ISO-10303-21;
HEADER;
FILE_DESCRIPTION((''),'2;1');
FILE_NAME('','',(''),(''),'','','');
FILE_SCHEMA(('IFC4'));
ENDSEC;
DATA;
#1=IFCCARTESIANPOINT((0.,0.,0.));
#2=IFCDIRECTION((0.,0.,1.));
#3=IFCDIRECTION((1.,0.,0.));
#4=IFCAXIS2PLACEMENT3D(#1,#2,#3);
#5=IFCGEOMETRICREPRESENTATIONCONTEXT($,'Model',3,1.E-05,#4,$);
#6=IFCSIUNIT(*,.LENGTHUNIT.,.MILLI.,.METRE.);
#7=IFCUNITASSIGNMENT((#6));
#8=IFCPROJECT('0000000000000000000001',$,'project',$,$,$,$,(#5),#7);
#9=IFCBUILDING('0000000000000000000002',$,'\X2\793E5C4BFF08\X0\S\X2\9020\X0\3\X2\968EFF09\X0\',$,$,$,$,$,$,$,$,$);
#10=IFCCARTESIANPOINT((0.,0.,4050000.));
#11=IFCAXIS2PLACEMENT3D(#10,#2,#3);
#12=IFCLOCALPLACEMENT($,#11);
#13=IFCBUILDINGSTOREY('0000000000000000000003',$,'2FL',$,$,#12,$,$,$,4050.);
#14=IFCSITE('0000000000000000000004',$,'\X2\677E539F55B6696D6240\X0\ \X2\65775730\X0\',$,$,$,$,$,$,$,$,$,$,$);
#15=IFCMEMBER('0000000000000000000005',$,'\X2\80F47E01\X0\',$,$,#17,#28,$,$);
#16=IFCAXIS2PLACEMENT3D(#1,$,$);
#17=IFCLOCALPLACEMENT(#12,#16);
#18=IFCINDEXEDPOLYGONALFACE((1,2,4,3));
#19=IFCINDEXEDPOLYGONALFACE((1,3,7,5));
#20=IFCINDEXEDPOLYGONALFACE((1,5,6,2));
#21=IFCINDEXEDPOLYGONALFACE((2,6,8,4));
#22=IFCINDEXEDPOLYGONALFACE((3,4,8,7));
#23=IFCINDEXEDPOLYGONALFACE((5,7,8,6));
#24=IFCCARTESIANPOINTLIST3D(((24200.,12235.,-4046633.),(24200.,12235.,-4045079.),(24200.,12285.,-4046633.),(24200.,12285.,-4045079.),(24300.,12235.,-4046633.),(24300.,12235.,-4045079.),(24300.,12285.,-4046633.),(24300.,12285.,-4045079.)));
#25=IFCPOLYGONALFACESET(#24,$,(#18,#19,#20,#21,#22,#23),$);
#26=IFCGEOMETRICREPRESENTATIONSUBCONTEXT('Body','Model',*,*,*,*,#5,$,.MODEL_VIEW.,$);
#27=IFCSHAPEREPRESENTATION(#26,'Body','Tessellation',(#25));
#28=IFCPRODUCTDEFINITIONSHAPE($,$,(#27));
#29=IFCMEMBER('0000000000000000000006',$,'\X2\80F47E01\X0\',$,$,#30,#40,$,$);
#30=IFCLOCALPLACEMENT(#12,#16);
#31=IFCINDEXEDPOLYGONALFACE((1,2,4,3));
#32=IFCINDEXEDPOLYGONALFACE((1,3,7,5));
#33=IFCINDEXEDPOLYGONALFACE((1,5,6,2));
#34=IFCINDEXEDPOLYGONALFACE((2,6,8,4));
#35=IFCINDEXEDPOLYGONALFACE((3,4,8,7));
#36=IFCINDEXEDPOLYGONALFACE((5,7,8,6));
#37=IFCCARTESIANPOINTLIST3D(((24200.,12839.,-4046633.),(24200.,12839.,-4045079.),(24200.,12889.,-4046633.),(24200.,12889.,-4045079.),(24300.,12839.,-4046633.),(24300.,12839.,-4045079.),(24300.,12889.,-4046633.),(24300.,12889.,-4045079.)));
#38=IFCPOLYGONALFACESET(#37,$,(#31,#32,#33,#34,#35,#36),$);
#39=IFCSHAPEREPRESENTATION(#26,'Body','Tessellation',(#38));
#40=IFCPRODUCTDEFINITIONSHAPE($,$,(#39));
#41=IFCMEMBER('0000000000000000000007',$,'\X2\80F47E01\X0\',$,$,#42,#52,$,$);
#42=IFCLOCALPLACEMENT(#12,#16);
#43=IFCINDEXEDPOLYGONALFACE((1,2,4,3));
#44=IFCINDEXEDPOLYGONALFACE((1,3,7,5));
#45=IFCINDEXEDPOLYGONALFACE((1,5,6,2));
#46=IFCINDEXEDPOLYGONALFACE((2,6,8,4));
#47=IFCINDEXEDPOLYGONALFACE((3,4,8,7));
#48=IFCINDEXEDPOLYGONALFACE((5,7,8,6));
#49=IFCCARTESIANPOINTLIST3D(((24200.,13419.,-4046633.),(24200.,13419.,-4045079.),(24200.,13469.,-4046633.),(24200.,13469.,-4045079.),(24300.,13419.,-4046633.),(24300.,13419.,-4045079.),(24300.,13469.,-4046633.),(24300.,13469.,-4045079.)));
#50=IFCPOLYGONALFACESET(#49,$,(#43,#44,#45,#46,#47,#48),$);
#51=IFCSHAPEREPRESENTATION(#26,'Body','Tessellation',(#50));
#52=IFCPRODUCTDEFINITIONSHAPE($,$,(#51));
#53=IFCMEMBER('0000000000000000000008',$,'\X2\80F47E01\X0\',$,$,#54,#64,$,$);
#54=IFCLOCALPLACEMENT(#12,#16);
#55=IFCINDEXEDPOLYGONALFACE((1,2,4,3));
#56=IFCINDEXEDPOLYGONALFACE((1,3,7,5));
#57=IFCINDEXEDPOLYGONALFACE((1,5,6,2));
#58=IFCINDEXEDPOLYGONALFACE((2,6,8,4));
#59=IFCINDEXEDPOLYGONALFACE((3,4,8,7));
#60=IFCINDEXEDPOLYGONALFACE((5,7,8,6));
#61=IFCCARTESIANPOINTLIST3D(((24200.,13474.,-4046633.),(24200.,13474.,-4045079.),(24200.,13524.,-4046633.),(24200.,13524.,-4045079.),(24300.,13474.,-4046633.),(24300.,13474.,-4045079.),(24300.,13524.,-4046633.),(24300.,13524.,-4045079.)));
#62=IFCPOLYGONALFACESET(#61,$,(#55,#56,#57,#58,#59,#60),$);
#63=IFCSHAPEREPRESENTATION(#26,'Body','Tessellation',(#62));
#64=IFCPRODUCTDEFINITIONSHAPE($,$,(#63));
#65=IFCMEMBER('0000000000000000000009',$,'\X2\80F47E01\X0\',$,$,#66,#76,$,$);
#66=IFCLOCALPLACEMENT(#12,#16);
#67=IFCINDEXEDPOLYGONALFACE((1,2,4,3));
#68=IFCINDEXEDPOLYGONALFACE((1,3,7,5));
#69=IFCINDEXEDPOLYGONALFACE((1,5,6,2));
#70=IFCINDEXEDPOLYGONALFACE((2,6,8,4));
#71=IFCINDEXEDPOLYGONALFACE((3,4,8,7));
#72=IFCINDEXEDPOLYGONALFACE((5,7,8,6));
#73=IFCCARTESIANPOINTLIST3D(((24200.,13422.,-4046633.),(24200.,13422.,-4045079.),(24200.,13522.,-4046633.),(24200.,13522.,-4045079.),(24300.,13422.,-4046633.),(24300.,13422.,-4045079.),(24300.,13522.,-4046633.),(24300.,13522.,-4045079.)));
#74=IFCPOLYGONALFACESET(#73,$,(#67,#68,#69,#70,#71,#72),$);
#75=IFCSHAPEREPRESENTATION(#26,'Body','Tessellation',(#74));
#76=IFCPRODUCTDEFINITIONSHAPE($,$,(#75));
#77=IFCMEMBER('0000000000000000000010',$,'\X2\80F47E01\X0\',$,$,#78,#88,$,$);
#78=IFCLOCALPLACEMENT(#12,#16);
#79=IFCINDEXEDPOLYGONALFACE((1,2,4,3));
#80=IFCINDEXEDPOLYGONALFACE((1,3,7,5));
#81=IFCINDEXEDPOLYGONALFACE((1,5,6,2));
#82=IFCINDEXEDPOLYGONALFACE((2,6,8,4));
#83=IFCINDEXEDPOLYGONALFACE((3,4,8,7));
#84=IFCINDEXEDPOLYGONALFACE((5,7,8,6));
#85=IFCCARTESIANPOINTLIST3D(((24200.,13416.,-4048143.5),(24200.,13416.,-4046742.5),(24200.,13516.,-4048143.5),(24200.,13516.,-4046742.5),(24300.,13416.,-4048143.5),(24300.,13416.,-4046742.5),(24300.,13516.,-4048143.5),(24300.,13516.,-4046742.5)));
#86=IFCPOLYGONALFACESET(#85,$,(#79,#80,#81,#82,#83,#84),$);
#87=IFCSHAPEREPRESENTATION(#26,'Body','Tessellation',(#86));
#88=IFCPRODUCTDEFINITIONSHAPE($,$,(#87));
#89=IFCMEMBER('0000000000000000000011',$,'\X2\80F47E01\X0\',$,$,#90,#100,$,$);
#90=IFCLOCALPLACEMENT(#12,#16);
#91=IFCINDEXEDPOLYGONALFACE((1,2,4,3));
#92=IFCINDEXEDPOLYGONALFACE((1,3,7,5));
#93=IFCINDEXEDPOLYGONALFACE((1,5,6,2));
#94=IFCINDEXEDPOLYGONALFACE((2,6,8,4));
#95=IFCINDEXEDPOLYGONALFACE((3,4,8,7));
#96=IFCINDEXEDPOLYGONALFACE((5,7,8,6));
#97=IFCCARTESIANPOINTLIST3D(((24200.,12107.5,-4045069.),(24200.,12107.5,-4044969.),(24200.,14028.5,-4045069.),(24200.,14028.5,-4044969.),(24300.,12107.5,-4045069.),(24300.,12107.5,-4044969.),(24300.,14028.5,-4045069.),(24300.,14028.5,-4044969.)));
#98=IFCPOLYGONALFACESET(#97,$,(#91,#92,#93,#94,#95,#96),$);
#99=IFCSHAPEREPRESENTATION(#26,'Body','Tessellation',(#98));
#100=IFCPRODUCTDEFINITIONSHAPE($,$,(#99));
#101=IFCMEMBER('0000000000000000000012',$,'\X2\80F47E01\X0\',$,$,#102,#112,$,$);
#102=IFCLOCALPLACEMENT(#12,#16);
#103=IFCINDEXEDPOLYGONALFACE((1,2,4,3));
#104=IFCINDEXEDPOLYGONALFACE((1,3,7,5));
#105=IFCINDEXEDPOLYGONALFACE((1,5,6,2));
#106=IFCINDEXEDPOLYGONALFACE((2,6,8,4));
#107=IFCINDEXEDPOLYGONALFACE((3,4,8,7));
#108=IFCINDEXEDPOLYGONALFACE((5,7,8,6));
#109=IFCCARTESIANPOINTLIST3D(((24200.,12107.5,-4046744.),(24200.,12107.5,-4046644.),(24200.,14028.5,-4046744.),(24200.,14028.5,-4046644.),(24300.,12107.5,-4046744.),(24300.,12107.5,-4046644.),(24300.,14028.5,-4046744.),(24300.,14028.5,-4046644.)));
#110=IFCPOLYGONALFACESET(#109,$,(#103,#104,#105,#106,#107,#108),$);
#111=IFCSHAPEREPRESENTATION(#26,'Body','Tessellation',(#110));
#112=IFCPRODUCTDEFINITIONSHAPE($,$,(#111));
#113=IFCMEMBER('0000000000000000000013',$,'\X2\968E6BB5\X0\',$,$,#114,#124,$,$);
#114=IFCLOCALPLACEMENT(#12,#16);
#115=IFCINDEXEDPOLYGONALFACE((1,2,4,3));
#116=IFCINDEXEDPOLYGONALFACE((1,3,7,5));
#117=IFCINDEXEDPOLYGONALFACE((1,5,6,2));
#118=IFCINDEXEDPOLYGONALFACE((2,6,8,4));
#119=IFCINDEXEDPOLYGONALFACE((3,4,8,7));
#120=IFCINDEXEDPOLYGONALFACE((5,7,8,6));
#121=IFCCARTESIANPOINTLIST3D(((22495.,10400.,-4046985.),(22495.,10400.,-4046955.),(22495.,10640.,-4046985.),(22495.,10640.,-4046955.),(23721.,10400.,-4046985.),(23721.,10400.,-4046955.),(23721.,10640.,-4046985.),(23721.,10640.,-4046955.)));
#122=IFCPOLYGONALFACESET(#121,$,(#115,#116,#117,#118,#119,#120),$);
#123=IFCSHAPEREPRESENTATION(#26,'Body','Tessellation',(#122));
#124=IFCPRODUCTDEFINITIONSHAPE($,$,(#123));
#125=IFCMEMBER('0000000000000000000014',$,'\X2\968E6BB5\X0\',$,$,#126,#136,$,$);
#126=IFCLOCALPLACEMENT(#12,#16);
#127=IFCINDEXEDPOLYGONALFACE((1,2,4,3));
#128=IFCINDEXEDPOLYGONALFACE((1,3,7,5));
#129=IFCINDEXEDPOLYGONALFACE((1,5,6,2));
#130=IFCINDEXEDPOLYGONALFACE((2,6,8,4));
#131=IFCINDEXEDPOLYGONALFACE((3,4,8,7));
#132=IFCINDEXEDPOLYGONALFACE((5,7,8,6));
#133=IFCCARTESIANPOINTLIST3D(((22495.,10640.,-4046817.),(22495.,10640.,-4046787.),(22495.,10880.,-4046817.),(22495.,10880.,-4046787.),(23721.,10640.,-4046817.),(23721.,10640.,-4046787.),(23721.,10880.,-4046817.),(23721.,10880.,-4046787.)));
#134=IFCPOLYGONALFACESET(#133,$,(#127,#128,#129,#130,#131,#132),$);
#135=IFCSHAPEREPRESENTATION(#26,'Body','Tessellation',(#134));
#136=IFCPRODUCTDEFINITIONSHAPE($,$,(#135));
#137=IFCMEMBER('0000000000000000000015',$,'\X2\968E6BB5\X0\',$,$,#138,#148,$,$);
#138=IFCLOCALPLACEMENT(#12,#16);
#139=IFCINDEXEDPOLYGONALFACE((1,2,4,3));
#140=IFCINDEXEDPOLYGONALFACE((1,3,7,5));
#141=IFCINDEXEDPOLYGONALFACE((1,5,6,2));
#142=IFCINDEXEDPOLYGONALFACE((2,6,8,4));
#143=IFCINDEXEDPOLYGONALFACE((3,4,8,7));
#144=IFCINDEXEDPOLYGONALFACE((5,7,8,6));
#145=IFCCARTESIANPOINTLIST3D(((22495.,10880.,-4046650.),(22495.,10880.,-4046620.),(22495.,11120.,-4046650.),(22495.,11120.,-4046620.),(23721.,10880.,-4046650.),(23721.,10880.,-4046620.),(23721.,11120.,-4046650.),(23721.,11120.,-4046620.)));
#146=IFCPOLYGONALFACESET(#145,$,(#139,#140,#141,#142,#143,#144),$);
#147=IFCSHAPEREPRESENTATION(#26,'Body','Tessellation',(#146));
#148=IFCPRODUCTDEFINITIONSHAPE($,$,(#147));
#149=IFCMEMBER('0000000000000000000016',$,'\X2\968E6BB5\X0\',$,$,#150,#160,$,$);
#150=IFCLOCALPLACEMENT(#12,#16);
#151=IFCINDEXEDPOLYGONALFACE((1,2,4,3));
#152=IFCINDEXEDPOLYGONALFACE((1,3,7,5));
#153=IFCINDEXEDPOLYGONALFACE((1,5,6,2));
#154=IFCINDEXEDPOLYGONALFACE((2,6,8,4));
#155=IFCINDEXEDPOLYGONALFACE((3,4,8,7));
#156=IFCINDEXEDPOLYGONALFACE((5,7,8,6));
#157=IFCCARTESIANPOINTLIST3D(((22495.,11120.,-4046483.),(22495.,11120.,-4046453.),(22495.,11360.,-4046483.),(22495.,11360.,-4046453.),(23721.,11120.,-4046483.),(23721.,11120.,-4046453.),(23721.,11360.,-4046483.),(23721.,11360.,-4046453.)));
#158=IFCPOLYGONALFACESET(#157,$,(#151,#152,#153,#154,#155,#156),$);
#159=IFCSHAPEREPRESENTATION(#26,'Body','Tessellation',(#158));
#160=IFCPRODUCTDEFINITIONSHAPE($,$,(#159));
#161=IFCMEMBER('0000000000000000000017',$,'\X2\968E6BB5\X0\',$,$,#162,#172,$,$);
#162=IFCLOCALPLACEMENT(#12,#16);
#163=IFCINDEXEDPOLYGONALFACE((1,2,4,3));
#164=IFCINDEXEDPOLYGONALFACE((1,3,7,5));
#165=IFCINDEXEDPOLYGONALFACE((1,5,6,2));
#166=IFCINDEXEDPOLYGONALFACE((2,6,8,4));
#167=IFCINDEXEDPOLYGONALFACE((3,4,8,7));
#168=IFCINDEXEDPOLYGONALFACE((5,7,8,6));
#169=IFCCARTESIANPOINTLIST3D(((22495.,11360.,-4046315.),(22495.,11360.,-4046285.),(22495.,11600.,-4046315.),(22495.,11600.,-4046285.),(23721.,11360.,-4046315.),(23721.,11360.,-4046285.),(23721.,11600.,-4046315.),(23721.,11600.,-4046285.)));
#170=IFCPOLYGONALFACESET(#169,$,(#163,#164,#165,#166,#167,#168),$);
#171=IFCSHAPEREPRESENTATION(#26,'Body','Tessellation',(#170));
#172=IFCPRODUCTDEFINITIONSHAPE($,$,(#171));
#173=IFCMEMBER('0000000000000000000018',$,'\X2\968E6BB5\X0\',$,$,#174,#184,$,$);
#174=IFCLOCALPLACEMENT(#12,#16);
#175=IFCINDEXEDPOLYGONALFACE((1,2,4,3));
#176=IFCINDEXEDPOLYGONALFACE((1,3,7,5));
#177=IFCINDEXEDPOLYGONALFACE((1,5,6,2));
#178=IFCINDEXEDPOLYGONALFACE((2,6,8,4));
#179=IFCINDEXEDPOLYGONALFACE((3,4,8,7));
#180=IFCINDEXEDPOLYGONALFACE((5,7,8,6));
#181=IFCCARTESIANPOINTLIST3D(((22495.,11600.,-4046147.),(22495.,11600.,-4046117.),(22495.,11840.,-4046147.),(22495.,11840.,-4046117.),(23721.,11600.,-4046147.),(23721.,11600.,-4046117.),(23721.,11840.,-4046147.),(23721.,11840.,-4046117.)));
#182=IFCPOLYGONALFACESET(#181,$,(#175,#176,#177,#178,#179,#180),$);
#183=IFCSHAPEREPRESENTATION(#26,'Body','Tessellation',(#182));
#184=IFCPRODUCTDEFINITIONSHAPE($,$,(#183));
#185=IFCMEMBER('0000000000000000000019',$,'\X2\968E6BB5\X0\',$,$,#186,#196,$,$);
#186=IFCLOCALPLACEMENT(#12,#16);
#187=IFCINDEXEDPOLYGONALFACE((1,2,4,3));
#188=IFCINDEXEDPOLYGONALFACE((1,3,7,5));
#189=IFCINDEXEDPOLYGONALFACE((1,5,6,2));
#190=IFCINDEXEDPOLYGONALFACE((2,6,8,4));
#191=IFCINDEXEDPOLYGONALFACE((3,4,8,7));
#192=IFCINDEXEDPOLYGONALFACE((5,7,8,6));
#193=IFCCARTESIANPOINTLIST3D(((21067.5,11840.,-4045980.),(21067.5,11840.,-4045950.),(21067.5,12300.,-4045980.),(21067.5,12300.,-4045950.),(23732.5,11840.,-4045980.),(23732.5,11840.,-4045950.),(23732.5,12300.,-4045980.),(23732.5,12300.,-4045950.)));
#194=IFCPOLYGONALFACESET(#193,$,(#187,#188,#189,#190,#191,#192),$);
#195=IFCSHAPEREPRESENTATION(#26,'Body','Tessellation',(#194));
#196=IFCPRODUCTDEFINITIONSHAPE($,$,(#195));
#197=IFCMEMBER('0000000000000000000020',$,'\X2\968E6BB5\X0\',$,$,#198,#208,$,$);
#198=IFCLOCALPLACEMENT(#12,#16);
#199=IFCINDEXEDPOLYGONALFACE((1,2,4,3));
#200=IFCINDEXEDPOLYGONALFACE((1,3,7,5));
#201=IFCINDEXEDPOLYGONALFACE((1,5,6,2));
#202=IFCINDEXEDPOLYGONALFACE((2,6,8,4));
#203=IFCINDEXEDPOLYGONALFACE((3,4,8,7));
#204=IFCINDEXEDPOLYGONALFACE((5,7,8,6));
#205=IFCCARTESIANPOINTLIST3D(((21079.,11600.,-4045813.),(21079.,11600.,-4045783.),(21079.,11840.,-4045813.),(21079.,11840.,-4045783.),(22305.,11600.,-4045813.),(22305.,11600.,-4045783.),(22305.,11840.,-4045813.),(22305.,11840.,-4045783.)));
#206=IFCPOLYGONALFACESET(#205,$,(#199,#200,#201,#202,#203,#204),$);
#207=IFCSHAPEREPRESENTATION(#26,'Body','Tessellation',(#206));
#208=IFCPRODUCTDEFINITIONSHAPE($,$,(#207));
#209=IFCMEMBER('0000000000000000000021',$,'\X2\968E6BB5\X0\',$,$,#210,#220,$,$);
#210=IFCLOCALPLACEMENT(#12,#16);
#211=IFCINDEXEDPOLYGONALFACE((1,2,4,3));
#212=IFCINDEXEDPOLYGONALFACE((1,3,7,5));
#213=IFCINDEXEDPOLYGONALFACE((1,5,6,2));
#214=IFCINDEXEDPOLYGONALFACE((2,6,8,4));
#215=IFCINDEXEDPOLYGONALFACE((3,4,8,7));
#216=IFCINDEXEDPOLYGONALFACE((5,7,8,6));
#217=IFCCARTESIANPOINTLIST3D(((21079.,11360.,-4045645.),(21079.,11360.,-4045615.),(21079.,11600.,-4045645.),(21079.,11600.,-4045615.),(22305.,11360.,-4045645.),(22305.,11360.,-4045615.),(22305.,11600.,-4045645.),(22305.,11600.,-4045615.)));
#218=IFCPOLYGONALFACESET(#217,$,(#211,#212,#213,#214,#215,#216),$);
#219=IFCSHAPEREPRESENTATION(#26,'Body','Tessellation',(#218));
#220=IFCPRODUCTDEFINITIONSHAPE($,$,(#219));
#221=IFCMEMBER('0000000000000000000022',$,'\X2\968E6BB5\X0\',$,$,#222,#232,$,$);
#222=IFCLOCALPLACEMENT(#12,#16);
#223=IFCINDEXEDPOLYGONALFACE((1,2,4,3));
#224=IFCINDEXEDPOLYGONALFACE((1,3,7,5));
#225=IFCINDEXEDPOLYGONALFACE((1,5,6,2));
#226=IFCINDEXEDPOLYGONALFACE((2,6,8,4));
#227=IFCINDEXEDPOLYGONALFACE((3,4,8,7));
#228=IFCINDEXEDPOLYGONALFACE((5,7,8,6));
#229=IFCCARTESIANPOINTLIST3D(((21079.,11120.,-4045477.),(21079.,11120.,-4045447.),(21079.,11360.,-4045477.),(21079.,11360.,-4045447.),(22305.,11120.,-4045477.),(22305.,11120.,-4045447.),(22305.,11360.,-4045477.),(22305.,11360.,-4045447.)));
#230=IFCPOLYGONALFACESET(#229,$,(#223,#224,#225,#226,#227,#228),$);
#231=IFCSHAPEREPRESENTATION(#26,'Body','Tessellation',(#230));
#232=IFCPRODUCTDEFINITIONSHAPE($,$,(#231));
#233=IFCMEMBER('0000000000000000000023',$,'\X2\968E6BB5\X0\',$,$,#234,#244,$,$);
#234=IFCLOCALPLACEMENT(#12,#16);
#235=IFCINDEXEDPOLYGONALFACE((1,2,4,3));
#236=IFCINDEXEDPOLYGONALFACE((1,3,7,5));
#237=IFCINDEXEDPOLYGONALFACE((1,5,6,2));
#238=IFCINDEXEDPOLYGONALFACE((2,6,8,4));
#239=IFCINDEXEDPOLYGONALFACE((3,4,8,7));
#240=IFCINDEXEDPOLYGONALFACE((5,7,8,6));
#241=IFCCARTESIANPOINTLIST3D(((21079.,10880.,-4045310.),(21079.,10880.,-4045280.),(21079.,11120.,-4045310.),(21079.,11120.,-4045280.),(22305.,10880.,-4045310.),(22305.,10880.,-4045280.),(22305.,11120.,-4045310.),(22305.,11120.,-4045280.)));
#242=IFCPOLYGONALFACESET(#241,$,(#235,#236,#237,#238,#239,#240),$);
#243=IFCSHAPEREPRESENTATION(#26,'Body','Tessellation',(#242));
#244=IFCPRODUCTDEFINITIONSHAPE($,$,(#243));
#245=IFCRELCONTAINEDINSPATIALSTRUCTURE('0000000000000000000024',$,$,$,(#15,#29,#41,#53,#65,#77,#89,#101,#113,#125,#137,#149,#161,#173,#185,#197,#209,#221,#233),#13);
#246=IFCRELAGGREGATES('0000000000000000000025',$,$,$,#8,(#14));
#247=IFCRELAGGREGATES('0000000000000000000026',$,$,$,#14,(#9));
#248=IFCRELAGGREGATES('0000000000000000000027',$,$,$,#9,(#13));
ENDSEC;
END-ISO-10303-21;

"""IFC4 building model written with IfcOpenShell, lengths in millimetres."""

from ifc_helpers import new_model, si_unit, frame, origin, origin_with_axes, place, context, subcontext, project, spatial, rectangle, extrude, element, save


model = new_model("IFC4")

# Units and contexts
model_context = context("Model", 3, precision=1e-05, world=origin_with_axes())
body_context = subcontext(model_context, "Body", "Model", "MODEL_VIEW")
ifc_project = project(units=[si_unit("LENGTHUNIT", "METRE", prefix="MILLI")], contexts=[model_context])

# Site, building, storey
site = spatial("IfcSite", under=ifc_project, Name="松原営業所 敷地")
building = spatial("IfcBuilding", under=site, Name="社屋（S造3階）")
storey_placement = place(None, frame((0.0, 0.0, 4050000.0), z_axis=(0.0, 0.0, 1.0), x_axis=(1.0, 0.0, 0.0)))
storey = spatial("IfcBuildingStorey", under=building, at=storey_placement, Name="2FL", Elevation=4050.0)

# Members
for number, where, z_axis, x_axis, name in (
    (1, (24250.0, 12235.0, -4045856.0), (0.0, 1.0, 0.0), (-1.0, 0.0, 0.0), "胴縁"),
    (2, (24250.0, 12839.0, -4045856.0), (0.0, 1.0, 0.0), (-1.0, 0.0, 0.0), "胴縁"),
    (3, (24250.0, 13419.0, -4045856.0), (0.0, 1.0, 0.0), (-1.0, 0.0, 0.0), "胴縁"),
    (4, (24250.0, 13474.0, -4045856.0), (0.0, 1.0, 0.0), (-1.0, 0.0, 0.0), "胴縁"),
):
    element("IfcMember", number, at=place(storey_placement, frame(where, z_axis=z_axis, x_axis=x_axis)), inside=storey, Name=name, context=body_context, shape_type="SweptSolid", body=[
        extrude(rectangle(XDim=100.0, YDim=1554.0), origin(), (0.0, 0.0, 1.0), 50.0),
    ])
member_1_placement = place(storey_placement, frame((24250.0, 13422.0, -4045856.0), z_axis=(0.0, 1.0, 0.0), x_axis=(-1.0, 0.0, 0.0)))
element("IfcMember", 5, at=member_1_placement, inside=storey, Name="胴縁", context=body_context, shape_type="SweptSolid", body=[
    extrude(rectangle(XDim=100.0, YDim=1554.0), origin(), (0.0, 0.0, 1.0), 100.0),
])
member_2_placement = place(storey_placement, frame((24250.0, 13416.0, -4047443.0), z_axis=(0.0, 1.0, 0.0), x_axis=(-1.0, 0.0, 0.0)))
element("IfcMember", 6, at=member_2_placement, inside=storey, Name="胴縁", context=body_context, shape_type="SweptSolid", body=[
    extrude(rectangle(XDim=100.0, YDim=1401.0), origin(), (0.0, 0.0, 1.0), 100.0),
])
for number, where, z_axis, x_axis, name in (
    (7, (24250.0, 12107.5, -4045019.0), (0.0, 1.0, 0.0), (-1.0, 0.0, 0.0), "胴縁"),
    (8, (24250.0, 12107.5, -4046694.0), (0.0, 1.0, 0.0), (-1.0, 0.0, 0.0), "胴縁"),
):
    element("IfcMember", number, at=place(storey_placement, frame(where, z_axis=z_axis, x_axis=x_axis)), inside=storey, Name=name, context=body_context, shape_type="SweptSolid", body=[
        extrude(rectangle(XDim=100.0, YDim=100.0), origin(), (0.0, 0.0, 1.0), 1921.0),
    ])
for number, where, z_axis, x_axis, name in (
    (9, (23108.0, 10400.0, -4046970.0), (0.0, 1.0, 0.0), (-1.0, 0.0, 0.0), "階段"),
    (10, (23108.0, 10640.0, -4046802.0), (0.0, 1.0, 0.0), (-1.0, 0.0, 0.0), "階段"),
    (11, (23108.0, 10880.0, -4046635.0), (0.0, 1.0, 0.0), (-1.0, 0.0, 0.0), "階段"),
    (12, (23108.0, 11120.0, -4046468.0), (0.0, 1.0, 0.0), (-1.0, 0.0, 0.0), "階段"),
    (13, (23108.0, 11360.0, -4046300.0), (0.0, 1.0, 0.0), (-1.0, 0.0, 0.0), "階段"),
    (14, (23108.0, 11600.0, -4046132.0), (0.0, 1.0, 0.0), (-1.0, 0.0, 0.0), "階段"),
):
    element("IfcMember", number, at=place(storey_placement, frame(where, z_axis=z_axis, x_axis=x_axis)), inside=storey, Name=name, context=body_context, shape_type="SweptSolid", body=[
        extrude(rectangle(XDim=1226.0, YDim=30.0), origin(), (0.0, 0.0, 1.0), 240.0),
    ])
member_3_placement = place(storey_placement, frame((21067.5, 12070.0, -4045965.0), z_axis=(1.0, 0.0, 0.0), x_axis=(0.0, 1.0, 0.0)))
element("IfcMember", 15, at=member_3_placement, inside=storey, Name="階段", context=body_context, shape_type="SweptSolid", body=[
    extrude(rectangle(XDim=460.0, YDim=30.0), origin(), (0.0, 0.0, 1.0), 2665.0),
])
for number, where, z_axis, x_axis, name in (
    (16, (21692.0, 11600.0, -4045798.0), (0.0, 1.0, 0.0), (-1.0, 0.0, 0.0), "階段"),
    (17, (21692.0, 11360.0, -4045630.0), (0.0, 1.0, 0.0), (-1.0, 0.0, 0.0), "階段"),
    (18, (21692.0, 11120.0, -4045462.0), (0.0, 1.0, 0.0), (-1.0, 0.0, 0.0), "階段"),
    (19, (21692.0, 10880.0, -4045295.0), (0.0, 1.0, 0.0), (-1.0, 0.0, 0.0), "階段"),
):
    element("IfcMember", number, at=place(storey_placement, frame(where, z_axis=z_axis, x_axis=x_axis)), inside=storey, Name=name, context=body_context, shape_type="SweptSolid", body=[
        extrude(rectangle(XDim=1226.0, YDim=30.0), origin(), (0.0, 0.0, 1.0), 240.0),
    ])

save(model, "model.ifc")
